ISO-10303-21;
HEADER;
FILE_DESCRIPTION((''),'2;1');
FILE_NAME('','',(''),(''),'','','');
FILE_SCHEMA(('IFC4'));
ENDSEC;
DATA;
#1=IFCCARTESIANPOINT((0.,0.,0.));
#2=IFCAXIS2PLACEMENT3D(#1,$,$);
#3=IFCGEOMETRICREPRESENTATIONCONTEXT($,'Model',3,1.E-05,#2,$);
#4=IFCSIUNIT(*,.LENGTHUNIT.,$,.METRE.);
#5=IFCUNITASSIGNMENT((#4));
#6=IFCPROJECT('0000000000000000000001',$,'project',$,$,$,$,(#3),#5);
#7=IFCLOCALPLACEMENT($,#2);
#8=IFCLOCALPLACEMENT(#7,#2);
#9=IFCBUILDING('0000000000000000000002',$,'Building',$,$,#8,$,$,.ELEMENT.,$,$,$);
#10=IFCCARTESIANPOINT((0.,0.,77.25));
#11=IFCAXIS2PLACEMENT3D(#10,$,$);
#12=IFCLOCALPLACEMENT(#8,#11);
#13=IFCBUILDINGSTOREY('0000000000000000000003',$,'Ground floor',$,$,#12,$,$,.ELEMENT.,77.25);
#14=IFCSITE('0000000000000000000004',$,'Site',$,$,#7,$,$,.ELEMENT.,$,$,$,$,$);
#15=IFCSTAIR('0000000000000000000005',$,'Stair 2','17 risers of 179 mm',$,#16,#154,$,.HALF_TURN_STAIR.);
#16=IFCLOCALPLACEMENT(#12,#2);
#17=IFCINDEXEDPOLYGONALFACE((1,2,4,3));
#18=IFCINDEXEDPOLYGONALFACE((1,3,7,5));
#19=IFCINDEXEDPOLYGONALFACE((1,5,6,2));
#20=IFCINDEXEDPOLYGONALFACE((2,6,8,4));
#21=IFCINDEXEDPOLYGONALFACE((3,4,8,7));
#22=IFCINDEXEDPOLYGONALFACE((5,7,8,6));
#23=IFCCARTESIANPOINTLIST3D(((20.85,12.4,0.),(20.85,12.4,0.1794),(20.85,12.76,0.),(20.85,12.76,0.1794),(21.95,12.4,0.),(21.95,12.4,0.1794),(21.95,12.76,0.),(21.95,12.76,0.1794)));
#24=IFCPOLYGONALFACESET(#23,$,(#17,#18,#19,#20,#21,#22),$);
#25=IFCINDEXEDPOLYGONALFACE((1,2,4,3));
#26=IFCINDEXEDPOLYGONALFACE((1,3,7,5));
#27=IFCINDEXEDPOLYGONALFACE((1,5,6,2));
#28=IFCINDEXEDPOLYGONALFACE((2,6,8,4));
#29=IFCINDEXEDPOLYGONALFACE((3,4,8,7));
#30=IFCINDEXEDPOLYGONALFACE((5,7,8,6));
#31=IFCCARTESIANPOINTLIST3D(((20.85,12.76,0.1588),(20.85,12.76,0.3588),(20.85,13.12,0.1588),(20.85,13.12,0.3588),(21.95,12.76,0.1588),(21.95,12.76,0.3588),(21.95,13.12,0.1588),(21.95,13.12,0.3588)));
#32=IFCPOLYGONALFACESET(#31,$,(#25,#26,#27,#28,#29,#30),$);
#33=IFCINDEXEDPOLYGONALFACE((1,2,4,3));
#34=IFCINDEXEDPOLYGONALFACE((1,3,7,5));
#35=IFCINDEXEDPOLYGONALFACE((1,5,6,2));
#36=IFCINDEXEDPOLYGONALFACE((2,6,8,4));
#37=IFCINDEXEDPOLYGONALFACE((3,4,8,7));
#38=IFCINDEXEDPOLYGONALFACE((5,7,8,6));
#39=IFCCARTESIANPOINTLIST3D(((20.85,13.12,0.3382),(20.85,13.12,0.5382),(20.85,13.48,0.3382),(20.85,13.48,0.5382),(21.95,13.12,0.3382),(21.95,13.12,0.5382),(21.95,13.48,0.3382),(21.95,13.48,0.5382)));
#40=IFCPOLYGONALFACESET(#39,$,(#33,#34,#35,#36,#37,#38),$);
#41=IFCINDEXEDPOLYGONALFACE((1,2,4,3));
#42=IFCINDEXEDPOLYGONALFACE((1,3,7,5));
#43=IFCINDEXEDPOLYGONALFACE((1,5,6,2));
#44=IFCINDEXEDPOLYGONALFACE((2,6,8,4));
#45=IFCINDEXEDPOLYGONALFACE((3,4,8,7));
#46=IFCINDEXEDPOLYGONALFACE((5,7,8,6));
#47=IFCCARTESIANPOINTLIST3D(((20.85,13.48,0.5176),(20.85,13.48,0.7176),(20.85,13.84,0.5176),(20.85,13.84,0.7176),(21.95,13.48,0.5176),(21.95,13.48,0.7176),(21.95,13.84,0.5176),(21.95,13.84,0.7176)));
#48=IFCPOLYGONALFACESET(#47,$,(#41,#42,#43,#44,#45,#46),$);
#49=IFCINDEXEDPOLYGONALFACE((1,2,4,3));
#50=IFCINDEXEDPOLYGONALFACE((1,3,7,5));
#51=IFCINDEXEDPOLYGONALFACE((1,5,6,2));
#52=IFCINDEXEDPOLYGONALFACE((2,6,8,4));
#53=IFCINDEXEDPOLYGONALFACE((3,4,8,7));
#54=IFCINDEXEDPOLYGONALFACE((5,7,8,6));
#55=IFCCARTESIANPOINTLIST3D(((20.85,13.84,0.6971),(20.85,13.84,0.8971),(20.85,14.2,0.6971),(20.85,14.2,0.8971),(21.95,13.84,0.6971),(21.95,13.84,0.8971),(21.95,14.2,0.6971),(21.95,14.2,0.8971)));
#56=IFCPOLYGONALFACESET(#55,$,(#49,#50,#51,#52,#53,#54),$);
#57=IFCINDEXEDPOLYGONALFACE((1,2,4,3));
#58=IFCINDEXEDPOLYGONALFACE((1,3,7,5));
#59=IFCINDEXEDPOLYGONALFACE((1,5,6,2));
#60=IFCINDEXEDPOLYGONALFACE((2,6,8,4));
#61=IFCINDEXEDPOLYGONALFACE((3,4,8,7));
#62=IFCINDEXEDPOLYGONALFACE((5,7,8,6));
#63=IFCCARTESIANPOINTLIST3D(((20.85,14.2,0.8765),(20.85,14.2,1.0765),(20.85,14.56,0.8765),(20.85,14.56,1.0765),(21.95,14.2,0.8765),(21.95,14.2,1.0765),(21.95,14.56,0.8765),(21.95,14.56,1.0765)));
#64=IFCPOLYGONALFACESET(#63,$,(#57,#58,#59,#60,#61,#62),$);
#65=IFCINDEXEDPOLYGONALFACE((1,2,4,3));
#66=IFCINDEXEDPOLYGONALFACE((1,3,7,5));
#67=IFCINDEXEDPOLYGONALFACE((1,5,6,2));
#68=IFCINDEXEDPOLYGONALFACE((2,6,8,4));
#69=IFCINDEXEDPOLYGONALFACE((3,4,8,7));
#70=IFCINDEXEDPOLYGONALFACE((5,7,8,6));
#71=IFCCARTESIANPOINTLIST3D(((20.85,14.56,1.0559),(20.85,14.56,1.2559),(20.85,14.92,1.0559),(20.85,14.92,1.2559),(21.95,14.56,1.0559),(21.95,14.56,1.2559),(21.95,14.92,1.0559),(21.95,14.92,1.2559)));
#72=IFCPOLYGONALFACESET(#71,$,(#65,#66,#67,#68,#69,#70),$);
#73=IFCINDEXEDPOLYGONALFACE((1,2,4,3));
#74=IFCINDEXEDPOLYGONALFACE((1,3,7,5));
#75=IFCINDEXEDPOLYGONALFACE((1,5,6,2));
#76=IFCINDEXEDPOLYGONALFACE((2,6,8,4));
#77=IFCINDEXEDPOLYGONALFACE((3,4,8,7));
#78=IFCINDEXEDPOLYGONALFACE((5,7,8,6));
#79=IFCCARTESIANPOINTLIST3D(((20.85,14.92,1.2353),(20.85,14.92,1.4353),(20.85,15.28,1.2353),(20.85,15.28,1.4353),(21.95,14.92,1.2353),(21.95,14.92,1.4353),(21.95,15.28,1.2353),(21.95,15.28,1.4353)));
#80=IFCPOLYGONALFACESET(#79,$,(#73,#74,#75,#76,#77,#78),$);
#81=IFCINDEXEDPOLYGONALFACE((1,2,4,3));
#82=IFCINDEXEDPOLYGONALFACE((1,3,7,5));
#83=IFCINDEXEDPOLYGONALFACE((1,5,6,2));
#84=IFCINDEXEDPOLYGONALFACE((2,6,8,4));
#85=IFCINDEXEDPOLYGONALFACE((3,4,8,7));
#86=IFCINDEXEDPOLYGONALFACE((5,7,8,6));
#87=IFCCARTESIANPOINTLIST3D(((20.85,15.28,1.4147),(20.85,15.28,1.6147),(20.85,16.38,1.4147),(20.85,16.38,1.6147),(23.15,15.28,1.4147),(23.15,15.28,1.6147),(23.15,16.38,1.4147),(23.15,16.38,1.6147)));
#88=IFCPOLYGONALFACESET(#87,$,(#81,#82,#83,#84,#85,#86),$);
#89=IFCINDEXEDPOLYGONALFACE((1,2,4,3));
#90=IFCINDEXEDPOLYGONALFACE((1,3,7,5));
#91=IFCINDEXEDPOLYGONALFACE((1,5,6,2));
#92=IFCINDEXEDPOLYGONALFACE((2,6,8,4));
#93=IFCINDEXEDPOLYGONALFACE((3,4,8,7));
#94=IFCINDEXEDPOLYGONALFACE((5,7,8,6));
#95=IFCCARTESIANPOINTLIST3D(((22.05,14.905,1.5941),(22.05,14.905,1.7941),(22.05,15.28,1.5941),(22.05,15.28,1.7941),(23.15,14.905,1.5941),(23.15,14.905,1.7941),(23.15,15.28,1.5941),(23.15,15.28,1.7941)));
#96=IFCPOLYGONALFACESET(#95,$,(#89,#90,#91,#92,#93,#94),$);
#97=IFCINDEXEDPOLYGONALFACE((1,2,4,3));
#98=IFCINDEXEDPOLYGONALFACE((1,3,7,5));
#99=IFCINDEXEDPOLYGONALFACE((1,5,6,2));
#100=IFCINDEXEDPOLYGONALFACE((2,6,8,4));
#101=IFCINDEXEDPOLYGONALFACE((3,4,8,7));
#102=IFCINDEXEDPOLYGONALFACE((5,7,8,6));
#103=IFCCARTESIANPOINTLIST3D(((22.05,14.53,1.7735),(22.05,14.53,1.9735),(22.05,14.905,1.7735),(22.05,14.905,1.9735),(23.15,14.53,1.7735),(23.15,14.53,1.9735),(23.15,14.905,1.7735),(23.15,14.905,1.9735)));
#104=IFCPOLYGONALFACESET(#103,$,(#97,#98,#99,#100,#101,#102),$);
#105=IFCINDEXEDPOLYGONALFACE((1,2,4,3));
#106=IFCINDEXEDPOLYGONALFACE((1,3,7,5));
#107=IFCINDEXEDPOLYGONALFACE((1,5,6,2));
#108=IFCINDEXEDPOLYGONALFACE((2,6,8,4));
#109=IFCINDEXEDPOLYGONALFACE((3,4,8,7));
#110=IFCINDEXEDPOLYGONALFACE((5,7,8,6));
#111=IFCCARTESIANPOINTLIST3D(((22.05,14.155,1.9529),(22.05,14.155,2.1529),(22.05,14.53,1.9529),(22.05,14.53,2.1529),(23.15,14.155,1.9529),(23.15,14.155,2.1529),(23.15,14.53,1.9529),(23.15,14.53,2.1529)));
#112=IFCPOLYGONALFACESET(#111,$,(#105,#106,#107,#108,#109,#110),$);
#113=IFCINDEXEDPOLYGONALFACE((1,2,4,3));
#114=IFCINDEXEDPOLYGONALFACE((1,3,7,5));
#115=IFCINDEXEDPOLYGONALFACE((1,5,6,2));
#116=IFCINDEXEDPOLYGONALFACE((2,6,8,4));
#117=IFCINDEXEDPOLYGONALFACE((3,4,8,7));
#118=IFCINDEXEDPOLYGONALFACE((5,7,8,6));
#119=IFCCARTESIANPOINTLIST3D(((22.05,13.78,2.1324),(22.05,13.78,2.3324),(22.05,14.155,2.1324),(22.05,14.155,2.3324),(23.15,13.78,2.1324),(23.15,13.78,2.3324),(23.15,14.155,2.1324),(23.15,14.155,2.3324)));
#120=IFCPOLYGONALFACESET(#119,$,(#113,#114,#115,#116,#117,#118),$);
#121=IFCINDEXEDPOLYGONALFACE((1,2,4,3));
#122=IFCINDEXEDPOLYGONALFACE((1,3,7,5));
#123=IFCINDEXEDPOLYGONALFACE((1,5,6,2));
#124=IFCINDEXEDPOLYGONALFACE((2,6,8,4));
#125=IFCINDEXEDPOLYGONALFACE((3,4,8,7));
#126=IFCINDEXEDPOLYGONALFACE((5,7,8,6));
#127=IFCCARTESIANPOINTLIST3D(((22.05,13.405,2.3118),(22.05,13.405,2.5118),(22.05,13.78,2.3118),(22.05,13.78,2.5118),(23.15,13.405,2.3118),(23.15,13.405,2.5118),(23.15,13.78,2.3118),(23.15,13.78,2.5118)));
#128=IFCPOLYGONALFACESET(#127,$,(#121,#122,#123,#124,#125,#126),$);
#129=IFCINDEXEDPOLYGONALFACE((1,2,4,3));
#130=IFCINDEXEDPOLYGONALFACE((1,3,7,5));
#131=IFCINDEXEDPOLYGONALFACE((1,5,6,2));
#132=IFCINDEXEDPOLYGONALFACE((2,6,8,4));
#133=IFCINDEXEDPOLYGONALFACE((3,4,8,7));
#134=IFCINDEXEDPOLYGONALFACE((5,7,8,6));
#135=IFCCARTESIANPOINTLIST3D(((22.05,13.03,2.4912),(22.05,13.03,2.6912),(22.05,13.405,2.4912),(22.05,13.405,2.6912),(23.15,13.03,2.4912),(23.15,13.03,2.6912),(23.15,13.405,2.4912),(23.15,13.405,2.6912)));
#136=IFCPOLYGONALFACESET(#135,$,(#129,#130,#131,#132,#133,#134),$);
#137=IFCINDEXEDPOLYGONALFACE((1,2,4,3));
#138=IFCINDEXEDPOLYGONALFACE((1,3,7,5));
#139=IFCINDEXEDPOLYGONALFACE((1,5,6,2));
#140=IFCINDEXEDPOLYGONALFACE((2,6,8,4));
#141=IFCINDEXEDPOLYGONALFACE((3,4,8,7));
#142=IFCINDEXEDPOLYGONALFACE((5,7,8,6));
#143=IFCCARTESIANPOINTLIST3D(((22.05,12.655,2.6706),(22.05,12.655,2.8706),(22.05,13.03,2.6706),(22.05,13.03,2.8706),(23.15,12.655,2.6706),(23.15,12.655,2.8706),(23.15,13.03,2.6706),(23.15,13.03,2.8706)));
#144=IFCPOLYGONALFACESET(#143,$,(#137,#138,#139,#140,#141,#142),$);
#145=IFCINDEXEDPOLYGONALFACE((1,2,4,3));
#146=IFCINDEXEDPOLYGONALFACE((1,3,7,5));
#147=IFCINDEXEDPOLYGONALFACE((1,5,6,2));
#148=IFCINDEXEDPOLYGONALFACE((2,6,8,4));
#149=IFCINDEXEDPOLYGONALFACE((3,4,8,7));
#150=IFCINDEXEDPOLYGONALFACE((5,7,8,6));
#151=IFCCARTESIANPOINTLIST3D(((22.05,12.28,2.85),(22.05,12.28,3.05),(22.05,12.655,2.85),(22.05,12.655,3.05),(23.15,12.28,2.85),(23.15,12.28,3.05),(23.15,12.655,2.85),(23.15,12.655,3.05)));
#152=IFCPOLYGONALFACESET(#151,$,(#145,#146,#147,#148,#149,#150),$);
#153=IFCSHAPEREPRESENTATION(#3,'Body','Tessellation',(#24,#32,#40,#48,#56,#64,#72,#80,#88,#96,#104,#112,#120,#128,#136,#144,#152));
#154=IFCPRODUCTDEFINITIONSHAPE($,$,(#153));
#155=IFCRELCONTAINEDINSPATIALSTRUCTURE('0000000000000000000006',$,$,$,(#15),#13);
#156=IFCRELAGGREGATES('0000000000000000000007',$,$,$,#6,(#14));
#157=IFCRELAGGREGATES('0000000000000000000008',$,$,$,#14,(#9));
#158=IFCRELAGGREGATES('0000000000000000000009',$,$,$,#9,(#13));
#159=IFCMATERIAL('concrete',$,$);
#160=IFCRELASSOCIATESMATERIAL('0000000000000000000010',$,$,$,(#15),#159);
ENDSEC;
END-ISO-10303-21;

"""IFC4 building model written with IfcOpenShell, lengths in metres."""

from ifc_helpers import new_model, si_unit, frame, origin, place, context, project, spatial, polyline, outline, extrude, material, element, save


model = new_model("IFC4")

# Units and contexts
model_context = context("Model", 3, precision=1e-05, world=origin())
ifc_project = project(units=[si_unit("LENGTHUNIT", "METRE")], contexts=[model_context])

# Site, building, storey
site_placement = place(None, origin())
site = spatial("IfcSite", under=ifc_project, at=site_placement, Name="Site", CompositionType="ELEMENT")
building_placement = place(site_placement, origin())
building = spatial("IfcBuilding", under=site, at=building_placement, Name="Building", CompositionType="ELEMENT")
storey_placement = place(building_placement, frame((0.0, 0.0, 77.25)))
storey = spatial("IfcBuildingStorey", under=building, at=storey_placement, Name="Ground floor", CompositionType="ELEMENT", Elevation=77.25)

# Shared definitions
ifc_material = material(Name="concrete")

# Stair
stair_1_placement = place(storey_placement, frame((21.4, 12.4, 0.0), z_axis=(0.0, 0.0, 1.0), x_axis=(0.0, 1.0, 0.0)))
element("IfcStair", 1, at=stair_1_placement, inside=storey, material=ifc_material, Name="Stair 2", Description="17 risers of 179 mm", PredefinedType="HALF_TURN_STAIR", context=model_context, shape_type="SweptSolid", body=[
    extrude(outline(polyline([(0.0, -0.55), (0.36, -0.55), (0.36, 0.55), (0.0, 0.55), (0.0, -0.55)])), origin(), (0.0, 0.0, 1.0), 0.1794),
    extrude(outline(polyline([(0.36, -0.55), (0.72, -0.55), (0.72, 0.55), (0.36, 0.55), (0.36, -0.55)])), frame((0.0, 0.0, 0.1588)), (0.0, 0.0, 1.0), 0.2),
    extrude(outline(polyline([(0.72, -0.55), (1.08, -0.55), (1.08, 0.55), (0.72, 0.55), (0.72, -0.55)])), frame((0.0, 0.0, 0.3382)), (0.0, 0.0, 1.0), 0.2),
    extrude(outline(polyline([(1.08, -0.55), (1.44, -0.55), (1.44, 0.55), (1.08, 0.55), (1.08, -0.55)])), frame((0.0, 0.0, 0.5176)), (0.0, 0.0, 1.0), 0.2),
    extrude(outline(polyline([(1.44, -0.55), (1.8, -0.55), (1.8, 0.55), (1.44, 0.55), (1.44, -0.55)])), frame((0.0, 0.0, 0.6971)), (0.0, 0.0, 1.0), 0.2),
    extrude(outline(polyline([(1.8, -0.55), (2.16, -0.55), (2.16, 0.55), (1.8, 0.55), (1.8, -0.55)])), frame((0.0, 0.0, 0.8765)), (0.0, 0.0, 1.0), 0.2),
    extrude(outline(polyline([(2.16, -0.55), (2.52, -0.55), (2.52, 0.55), (2.16, 0.55), (2.16, -0.55)])), frame((0.0, 0.0, 1.0559)), (0.0, 0.0, 1.0), 0.2),
    extrude(outline(polyline([(2.52, -0.55), (2.88, -0.55), (2.88, 0.55), (2.52, 0.55), (2.52, -0.55)])), frame((0.0, 0.0, 1.2353)), (0.0, 0.0, 1.0), 0.2),
    extrude(outline(polyline([(2.88, -1.75), (3.98, -1.75), (3.98, 0.55), (2.88, 0.55), (2.88, -1.75)])), frame((0.0, 0.0, 1.4147)), (0.0, 0.0, 1.0), 0.2),
    extrude(outline(polyline([(2.505, -1.75), (2.88, -1.75), (2.88, -0.65), (2.505, -0.65), (2.505, -1.75)])), frame((0.0, 0.0, 1.5941)), (0.0, 0.0, 1.0), 0.2),
    extrude(outline(polyline([(2.13, -1.75), (2.505, -1.75), (2.505, -0.65), (2.13, -0.65), (2.13, -1.75)])), frame((0.0, 0.0, 1.7735)), (0.0, 0.0, 1.0), 0.2),
    extrude(outline(polyline([(1.755, -1.75), (2.13, -1.75), (2.13, -0.65), (1.755, -0.65), (1.755, -1.75)])), frame((0.0, 0.0, 1.9529)), (0.0, 0.0, 1.0), 0.2),
    extrude(outline(polyline([(1.38, -1.75), (1.755, -1.75), (1.755, -0.65), (1.38, -0.65), (1.38, -1.75)])), frame((0.0, 0.0, 2.1324)), (0.0, 0.0, 1.0), 0.2),
    extrude(outline(polyline([(1.005, -1.75), (1.38, -1.75), (1.38, -0.65), (1.005, -0.65), (1.005, -1.75)])), frame((0.0, 0.0, 2.3118)), (0.0, 0.0, 1.0), 0.2),
    extrude(outline(polyline([(0.63, -1.75), (1.005, -1.75), (1.005, -0.65), (0.63, -0.65), (0.63, -1.75)])), frame((0.0, 0.0, 2.4912)), (0.0, 0.0, 1.0), 0.2),
    extrude(outline(polyline([(0.255, -1.75), (0.63, -1.75), (0.63, -0.65), (0.255, -0.65), (0.255, -1.75)])), frame((0.0, 0.0, 2.6706)), (0.0, 0.0, 1.0), 0.2),
    extrude(outline(polyline([(-0.12, -1.75), (0.255, -1.75), (0.255, -0.65), (-0.12, -0.65), (-0.12, -1.75)])), frame((0.0, 0.0, 2.85)), (0.0, 0.0, 1.0), 0.2),
])

save(model, "model.ifc")
